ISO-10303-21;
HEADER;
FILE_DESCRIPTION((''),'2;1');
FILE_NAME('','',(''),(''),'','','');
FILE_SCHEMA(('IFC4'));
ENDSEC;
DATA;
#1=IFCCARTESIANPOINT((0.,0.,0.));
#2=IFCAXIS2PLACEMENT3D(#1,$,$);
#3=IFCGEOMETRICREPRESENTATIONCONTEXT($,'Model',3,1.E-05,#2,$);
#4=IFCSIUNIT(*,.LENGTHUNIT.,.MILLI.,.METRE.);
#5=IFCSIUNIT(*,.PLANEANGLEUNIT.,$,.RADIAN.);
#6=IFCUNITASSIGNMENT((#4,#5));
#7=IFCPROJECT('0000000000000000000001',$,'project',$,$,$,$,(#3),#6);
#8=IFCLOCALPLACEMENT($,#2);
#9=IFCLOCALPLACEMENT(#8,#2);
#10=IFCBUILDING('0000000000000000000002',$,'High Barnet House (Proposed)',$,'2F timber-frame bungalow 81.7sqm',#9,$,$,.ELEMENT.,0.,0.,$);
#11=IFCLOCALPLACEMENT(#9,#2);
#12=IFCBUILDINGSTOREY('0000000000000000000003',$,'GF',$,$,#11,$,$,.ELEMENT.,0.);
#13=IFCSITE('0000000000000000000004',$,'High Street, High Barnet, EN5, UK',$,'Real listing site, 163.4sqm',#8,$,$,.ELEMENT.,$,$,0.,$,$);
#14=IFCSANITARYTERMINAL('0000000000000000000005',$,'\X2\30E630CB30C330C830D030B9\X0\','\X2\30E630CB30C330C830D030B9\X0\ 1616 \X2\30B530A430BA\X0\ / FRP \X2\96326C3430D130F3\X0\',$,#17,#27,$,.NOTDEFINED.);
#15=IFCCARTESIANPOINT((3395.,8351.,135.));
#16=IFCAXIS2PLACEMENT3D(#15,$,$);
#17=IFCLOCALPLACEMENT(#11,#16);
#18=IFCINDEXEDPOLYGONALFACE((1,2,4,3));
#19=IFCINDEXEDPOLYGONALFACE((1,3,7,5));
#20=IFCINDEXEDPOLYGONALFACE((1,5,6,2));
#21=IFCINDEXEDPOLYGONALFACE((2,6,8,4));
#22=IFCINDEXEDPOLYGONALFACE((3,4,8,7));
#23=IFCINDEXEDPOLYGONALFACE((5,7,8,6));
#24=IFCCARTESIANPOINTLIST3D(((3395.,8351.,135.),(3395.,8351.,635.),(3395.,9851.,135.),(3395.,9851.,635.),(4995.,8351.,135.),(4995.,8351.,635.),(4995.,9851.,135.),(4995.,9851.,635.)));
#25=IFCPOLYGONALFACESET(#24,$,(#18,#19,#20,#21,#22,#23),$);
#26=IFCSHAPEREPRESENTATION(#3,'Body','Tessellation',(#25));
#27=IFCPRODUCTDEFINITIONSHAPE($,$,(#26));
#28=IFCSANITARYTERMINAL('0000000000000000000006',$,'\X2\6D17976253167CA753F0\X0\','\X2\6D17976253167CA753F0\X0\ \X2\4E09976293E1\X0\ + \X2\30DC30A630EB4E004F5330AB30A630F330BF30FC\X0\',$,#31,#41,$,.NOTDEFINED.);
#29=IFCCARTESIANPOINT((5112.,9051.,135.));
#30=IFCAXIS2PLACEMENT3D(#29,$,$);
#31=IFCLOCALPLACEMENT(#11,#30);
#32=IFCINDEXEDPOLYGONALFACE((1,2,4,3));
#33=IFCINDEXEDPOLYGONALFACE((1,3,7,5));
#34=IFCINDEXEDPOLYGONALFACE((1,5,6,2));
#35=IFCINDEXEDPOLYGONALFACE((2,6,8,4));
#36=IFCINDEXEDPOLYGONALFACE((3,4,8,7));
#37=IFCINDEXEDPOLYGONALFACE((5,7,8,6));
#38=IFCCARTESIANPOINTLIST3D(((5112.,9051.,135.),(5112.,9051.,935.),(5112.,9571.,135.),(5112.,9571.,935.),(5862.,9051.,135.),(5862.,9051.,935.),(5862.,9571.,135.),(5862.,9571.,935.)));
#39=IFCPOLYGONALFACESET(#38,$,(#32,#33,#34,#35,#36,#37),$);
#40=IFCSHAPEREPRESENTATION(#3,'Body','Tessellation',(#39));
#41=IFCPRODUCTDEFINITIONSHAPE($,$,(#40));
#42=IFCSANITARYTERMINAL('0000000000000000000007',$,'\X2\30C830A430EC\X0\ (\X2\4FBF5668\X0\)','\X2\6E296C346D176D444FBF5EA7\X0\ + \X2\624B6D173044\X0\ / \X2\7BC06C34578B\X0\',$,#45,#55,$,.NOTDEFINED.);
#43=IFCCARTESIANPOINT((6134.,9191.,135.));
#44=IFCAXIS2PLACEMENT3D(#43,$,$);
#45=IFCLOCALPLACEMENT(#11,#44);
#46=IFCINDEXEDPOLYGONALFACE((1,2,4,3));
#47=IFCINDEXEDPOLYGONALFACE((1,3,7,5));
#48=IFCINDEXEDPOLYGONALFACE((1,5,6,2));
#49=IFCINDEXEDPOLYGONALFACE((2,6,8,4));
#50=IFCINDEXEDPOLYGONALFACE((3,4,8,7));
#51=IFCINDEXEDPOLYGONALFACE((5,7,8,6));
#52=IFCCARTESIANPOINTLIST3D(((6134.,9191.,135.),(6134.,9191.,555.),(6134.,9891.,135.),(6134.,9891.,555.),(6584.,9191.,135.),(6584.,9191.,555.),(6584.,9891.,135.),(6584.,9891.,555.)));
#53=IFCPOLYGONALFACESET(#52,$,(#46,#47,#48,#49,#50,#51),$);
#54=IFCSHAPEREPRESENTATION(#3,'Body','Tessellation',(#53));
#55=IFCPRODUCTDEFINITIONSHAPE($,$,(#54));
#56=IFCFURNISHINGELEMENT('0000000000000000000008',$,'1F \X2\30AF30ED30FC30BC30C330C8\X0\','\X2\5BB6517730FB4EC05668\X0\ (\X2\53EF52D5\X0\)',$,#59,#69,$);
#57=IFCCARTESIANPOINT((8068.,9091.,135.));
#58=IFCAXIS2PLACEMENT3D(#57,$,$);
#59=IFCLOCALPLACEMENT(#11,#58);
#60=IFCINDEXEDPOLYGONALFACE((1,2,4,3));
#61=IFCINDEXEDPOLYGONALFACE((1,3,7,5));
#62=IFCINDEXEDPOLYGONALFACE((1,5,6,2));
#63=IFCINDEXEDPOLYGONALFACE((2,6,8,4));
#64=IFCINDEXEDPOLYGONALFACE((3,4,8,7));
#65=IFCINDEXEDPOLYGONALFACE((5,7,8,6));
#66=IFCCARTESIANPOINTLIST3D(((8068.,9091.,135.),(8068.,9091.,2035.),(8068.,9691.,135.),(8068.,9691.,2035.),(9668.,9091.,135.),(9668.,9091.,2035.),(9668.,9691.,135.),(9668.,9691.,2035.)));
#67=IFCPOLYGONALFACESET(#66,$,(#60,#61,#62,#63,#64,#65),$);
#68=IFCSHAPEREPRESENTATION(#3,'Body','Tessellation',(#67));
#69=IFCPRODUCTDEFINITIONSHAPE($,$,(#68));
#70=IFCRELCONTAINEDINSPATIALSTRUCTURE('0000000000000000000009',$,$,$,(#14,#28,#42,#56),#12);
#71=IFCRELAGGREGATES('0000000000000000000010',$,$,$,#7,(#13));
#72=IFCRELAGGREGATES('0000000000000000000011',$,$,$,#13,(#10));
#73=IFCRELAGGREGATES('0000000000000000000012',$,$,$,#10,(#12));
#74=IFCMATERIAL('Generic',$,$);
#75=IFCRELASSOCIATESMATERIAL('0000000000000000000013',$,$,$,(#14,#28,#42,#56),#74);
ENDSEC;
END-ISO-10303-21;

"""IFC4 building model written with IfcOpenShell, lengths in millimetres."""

from ifc_helpers import new_model, si_unit, frame, frame_2d, origin, place, context, project, spatial, rectangle, extrude, material, element, save


model = new_model("IFC4")

# Units and contexts
model_context = context("Model", 3, precision=1e-05, world=origin())
ifc_project = project(units=[si_unit("LENGTHUNIT", "METRE", prefix="MILLI"), si_unit("PLANEANGLEUNIT", "RADIAN")], contexts=[model_context])

# Site, building, storey
site_placement = place(None, origin())
site = spatial("IfcSite", under=ifc_project, at=site_placement, Name="High Street, High Barnet, EN5, UK", ObjectType="Real listing site, 163.4sqm", CompositionType="ELEMENT", RefElevation=0.0)
building_placement = place(site_placement, origin())
building = spatial("IfcBuilding", under=site, at=building_placement, Name="High Barnet House (Proposed)", ObjectType="2F timber-frame bungalow 81.7sqm", CompositionType="ELEMENT", ElevationOfRefHeight=0.0, ElevationOfTerrain=0.0)
storey_placement = place(building_placement, origin())
storey = spatial("IfcBuildingStorey", under=building, at=storey_placement, Name="GF", CompositionType="ELEMENT", Elevation=0.0)

# Shared definitions
ifc_material_1 = material(Name="Generic")

# Sanitary terminals
sanitary_terminal_1_placement = place(storey_placement, frame((3395.0, 8351.0, 135.0)))
element("IfcSanitaryTerminal", 1, at=sanitary_terminal_1_placement, inside=storey, material=ifc_material_1, Name="ユニットバス", Description="ユニットバス 1616 サイズ / FRP 防水パン", PredefinedType="NOTDEFINED", context=model_context, shape_type="SweptSolid", body=[
    extrude(rectangle(XDim=1600.0, YDim=1500.0, at=frame_2d((800.0, 750.0))), frame((3395.0, 8351.0, 135.0)), (0.0, 0.0, 1.0), 500.0),
])
sanitary_terminal_2_placement = place(storey_placement, frame((5112.0, 9051.0, 135.0)))
element("IfcSanitaryTerminal", 2, at=sanitary_terminal_2_placement, inside=storey, material=ifc_material_1, Name="洗面化粧台", Description="洗面化粧台 三面鏡 + ボウル一体カウンター", PredefinedType="NOTDEFINED", context=model_context, shape_type="SweptSolid", body=[
    extrude(rectangle(XDim=750.0, YDim=520.0, at=frame_2d((375.0, 260.0))), frame((5112.0, 9051.0, 135.0)), (0.0, 0.0, 1.0), 800.0),
])
sanitary_terminal_3_placement = place(storey_placement, frame((6134.0, 9191.0, 135.0)))
element("IfcSanitaryTerminal", 3, at=sanitary_terminal_3_placement, inside=storey, material=ifc_material_1, Name="トイレ (便器)", Description="温水洗浄便座 + 手洗い / 節水型", PredefinedType="NOTDEFINED", context=model_context, shape_type="SweptSolid", body=[
    extrude(rectangle(XDim=450.0, YDim=700.0, at=frame_2d((225.0, 350.0))), frame((6134.0, 9191.0, 135.0)), (0.0, 0.0, 1.0), 420.0),
])

# Furnishing element
furnishing_placement = place(storey_placement, frame((8068.0, 9091.0, 135.0)))
element("IfcFurnishingElement", 4, at=furnishing_placement, inside=storey, material=ifc_material_1, Name="1F クローゼット", Description="家具・什器 (可動)", context=model_context, shape_type="SweptSolid", body=[
    extrude(rectangle(XDim=1600.0, YDim=600.0, at=frame_2d((800.0, 300.0))), frame((8068.0, 9091.0, 135.0)), (0.0, 0.0, 1.0), 1900.0),
])

save(model, "model.ifc")
